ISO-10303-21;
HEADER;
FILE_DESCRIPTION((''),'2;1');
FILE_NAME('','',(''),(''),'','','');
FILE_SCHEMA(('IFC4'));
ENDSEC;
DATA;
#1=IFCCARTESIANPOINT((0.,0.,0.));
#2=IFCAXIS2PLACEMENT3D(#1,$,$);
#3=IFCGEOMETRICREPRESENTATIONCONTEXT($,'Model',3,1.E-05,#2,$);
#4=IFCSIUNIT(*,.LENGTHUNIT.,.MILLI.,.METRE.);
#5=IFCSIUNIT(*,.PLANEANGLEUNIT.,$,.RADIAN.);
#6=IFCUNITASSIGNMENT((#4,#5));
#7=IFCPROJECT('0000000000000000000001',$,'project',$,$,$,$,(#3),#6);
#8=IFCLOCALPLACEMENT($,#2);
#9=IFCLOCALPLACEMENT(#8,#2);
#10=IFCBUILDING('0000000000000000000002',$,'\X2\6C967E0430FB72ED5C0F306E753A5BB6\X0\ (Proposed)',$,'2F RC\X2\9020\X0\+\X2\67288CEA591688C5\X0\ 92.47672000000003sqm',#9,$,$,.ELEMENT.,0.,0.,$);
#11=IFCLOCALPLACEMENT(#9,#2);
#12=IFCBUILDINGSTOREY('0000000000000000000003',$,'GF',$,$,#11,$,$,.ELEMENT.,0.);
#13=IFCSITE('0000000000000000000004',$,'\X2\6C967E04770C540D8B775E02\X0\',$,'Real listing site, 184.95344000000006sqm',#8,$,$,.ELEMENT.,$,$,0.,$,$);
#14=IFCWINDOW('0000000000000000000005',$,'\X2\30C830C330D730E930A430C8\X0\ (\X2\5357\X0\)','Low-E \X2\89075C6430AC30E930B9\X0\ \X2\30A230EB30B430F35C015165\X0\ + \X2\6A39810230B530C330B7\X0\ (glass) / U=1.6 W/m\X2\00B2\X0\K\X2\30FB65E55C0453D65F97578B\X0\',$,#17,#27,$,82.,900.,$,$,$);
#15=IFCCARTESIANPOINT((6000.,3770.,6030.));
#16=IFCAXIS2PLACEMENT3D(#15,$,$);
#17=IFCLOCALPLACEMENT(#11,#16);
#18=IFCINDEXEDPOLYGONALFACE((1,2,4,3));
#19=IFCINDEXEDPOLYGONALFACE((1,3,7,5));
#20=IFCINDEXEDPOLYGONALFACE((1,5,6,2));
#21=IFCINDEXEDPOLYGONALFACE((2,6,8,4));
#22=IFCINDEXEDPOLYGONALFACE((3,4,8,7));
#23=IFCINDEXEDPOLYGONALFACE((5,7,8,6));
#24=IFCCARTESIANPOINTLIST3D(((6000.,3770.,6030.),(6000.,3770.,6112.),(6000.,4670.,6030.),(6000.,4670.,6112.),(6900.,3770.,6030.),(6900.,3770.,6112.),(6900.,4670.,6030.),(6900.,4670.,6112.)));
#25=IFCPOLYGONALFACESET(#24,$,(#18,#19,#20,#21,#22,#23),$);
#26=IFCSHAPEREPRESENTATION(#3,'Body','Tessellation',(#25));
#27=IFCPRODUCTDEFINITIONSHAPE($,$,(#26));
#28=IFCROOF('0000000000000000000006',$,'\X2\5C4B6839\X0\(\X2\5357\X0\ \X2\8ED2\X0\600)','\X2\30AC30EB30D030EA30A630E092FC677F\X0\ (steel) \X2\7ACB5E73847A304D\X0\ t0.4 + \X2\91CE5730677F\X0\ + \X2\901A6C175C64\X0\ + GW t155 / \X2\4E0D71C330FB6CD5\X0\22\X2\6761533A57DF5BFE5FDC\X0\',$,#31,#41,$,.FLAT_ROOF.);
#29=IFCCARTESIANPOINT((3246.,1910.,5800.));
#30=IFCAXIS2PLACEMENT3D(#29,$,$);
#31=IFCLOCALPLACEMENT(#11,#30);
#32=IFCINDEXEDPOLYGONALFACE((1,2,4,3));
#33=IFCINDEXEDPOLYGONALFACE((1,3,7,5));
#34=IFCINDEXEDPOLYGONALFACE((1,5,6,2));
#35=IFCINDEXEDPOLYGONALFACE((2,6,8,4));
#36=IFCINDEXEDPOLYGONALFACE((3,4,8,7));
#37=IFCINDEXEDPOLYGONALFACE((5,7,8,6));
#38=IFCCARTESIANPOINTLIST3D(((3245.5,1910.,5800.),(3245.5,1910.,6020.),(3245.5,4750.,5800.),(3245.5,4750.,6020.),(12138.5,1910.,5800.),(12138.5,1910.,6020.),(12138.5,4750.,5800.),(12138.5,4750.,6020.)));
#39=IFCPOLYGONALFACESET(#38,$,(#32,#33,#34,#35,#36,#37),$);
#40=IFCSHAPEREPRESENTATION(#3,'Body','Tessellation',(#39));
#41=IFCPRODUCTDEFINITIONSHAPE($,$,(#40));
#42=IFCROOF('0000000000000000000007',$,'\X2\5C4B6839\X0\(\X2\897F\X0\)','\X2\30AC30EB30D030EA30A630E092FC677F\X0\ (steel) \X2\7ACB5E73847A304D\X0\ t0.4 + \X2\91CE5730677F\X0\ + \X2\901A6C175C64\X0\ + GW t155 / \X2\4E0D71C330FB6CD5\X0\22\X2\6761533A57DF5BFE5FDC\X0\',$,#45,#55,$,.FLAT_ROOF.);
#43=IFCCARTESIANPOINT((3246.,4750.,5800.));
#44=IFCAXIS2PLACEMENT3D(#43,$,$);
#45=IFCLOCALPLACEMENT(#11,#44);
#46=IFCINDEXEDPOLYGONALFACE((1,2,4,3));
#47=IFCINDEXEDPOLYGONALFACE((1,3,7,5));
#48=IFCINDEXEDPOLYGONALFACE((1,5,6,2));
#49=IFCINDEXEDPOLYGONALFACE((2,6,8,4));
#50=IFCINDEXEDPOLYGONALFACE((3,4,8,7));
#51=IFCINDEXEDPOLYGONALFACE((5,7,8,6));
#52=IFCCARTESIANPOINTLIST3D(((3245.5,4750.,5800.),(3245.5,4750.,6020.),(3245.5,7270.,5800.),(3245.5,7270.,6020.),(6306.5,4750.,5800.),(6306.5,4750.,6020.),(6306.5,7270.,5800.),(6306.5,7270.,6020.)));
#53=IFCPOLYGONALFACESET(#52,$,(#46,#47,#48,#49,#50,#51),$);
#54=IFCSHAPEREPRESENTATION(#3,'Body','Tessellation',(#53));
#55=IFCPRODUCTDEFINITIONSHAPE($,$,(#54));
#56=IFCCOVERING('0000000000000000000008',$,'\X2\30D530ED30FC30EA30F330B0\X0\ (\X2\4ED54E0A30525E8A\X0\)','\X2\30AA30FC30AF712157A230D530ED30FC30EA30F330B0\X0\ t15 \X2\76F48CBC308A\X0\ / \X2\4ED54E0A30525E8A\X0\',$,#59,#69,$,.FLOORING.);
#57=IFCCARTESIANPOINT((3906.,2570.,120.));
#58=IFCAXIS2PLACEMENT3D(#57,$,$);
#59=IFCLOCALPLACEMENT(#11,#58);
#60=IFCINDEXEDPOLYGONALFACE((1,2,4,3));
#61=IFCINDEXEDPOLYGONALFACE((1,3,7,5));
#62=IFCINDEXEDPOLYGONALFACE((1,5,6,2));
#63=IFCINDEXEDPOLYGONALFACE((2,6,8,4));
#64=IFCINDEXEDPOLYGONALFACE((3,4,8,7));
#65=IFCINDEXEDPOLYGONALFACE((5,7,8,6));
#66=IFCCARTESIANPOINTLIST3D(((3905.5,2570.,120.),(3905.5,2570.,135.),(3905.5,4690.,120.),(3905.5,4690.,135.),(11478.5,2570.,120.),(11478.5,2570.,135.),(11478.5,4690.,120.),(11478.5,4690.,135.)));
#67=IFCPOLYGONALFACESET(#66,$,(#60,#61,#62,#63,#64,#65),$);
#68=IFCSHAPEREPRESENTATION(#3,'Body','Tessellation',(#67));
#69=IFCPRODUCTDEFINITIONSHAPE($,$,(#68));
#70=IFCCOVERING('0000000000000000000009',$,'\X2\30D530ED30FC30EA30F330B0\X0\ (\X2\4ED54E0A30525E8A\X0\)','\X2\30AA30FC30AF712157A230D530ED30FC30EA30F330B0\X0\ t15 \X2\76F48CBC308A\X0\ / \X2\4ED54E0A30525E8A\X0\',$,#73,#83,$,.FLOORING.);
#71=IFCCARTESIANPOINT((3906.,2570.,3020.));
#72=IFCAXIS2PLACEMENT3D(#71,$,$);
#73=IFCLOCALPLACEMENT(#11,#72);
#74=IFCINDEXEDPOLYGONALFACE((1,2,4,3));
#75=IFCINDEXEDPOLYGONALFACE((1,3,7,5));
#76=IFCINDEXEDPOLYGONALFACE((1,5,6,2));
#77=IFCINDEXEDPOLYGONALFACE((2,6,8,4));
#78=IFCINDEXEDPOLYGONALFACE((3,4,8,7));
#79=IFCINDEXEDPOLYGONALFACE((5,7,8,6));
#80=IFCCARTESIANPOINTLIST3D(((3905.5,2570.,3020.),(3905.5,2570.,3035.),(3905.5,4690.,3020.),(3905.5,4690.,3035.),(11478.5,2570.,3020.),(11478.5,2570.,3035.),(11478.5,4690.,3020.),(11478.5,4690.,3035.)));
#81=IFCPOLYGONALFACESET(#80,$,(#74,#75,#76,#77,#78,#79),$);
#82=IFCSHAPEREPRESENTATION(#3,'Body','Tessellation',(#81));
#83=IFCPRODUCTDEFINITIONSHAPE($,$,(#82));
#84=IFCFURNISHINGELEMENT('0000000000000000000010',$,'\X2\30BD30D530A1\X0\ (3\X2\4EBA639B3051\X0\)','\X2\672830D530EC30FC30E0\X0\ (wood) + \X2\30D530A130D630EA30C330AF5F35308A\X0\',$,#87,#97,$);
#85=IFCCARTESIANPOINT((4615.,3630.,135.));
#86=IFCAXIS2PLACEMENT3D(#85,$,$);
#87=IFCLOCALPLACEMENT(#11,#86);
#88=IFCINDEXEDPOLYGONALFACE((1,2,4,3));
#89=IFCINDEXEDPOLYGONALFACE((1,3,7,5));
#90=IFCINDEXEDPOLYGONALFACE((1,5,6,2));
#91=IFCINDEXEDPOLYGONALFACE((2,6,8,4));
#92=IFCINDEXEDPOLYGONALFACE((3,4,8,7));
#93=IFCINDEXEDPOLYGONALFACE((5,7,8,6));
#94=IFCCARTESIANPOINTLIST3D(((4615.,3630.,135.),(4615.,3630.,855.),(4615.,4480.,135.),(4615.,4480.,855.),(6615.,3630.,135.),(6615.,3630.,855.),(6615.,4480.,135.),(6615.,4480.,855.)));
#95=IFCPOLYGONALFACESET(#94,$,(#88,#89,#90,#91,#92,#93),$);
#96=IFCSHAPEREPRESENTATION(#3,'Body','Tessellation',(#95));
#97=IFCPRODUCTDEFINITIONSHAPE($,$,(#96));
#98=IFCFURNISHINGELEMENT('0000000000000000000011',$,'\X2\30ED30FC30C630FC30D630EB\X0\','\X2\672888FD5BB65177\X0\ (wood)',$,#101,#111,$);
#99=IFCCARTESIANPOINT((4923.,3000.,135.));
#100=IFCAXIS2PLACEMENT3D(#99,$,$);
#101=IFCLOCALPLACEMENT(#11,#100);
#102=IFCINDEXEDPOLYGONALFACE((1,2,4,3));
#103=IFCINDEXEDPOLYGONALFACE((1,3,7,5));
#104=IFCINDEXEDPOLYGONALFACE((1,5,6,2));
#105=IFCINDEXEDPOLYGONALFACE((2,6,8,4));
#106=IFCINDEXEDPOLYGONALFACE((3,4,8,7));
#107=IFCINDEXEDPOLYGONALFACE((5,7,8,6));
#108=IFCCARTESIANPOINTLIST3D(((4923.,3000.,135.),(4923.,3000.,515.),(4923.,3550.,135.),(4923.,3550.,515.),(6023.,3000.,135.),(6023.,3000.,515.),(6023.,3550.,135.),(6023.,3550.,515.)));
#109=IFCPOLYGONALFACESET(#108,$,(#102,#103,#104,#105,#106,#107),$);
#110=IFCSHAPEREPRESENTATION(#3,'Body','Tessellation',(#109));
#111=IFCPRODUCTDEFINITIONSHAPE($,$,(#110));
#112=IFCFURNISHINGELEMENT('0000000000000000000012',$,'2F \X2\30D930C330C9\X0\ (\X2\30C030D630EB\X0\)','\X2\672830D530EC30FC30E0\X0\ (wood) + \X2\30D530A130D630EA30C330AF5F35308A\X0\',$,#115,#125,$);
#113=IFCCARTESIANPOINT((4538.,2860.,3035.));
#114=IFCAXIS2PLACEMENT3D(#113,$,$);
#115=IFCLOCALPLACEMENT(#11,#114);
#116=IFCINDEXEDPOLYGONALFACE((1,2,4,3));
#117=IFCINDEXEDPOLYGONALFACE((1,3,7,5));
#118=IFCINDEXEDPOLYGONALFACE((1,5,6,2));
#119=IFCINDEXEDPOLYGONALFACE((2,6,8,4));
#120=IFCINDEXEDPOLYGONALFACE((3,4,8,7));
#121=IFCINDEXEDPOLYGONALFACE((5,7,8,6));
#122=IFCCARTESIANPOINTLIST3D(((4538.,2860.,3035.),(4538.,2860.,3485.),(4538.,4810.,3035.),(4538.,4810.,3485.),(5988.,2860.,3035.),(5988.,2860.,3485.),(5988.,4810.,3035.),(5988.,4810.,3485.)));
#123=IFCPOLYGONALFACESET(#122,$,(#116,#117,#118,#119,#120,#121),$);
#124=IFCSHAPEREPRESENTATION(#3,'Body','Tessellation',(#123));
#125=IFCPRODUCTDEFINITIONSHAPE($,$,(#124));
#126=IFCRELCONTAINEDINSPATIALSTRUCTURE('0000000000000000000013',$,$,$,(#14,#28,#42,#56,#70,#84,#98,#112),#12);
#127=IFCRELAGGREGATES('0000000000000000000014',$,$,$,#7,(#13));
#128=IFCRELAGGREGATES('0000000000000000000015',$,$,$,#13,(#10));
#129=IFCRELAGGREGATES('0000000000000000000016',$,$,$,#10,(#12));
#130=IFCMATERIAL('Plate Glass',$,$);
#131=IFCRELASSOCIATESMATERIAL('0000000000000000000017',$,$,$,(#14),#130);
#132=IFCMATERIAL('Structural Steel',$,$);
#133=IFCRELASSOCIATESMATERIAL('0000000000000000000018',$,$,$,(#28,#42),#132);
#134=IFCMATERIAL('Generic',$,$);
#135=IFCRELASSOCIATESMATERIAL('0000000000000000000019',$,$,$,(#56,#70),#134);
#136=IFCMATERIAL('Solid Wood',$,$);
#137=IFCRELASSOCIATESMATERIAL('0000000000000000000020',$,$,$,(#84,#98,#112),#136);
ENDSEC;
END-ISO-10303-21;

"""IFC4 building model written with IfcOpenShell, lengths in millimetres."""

from ifc_helpers import new_model, si_unit, frame, frame_2d, origin, place, context, project, spatial, rectangle, extrude, material, element, save


model = new_model("IFC4")

# Units and contexts
model_context = context("Model", 3, precision=1e-05, world=origin())
ifc_project = project(units=[si_unit("LENGTHUNIT", "METRE", prefix="MILLI"), si_unit("PLANEANGLEUNIT", "RADIAN")], contexts=[model_context])

# Site, building, storey
site_placement = place(None, origin())
site = spatial("IfcSite", under=ifc_project, at=site_placement, Name="沖縄県名護市", ObjectType="Real listing site, 184.95344000000006sqm", CompositionType="ELEMENT", RefElevation=0.0)
building_placement = place(site_placement, origin())
building = spatial("IfcBuilding", under=site, at=building_placement, Name="沖縄・狭小の町家 (Proposed)", ObjectType="2F RC造+木質外装 92.47672000000003sqm", CompositionType="ELEMENT", ElevationOfRefHeight=0.0, ElevationOfTerrain=0.0)
storey_placement = place(building_placement, origin())
storey = spatial("IfcBuildingStorey", under=building, at=storey_placement, Name="GF", CompositionType="ELEMENT", Elevation=0.0)

# Shared definitions
ifc_material_1 = material(Name="Solid Wood")

# Shared definitions
ifc_material_2 = material(Name="Plate Glass")

# Window
window_1_placement = place(storey_placement, frame((6000.0, 3770.0, 6030.0)))
element("IfcWindow", 1, at=window_1_placement, inside=storey, material=ifc_material_2, Name="トップライト (南)", Description="Low-E 複層ガラス アルゴン封入 + 樹脂サッシ (glass) / U=1.6 W/m²K・日射取得型", OverallHeight=82.0, OverallWidth=900.0, context=model_context, shape_type="SweptSolid", body=[
    extrude(rectangle(XDim=900.0, YDim=900.0, at=frame_2d((450.0, 450.0))), frame((6000.0, 3770.0, 6030.0)), (0.0, 0.0, 1.0), 82.0),
])

# Roofs
ifc_material_3 = material(Name="Structural Steel")
roof_1_placement = place(storey_placement, frame((3246.0, 1910.0, 5800.0)))
element("IfcRoof", 2, at=roof_1_placement, inside=storey, material=ifc_material_3, Name="屋根(南 軒600)", Description="ガルバリウム鋼板 (steel) 立平葺き t0.4 + 野地板 + 通気層 + GW t155 / 不燃・法22条区域対応", PredefinedType="FLAT_ROOF", context=model_context, shape_type="SweptSolid", body=[
    extrude(rectangle(XDim=8893.0, YDim=2840.0, at=frame_2d((4446.0, 1420.0))), frame((3246.0, 1910.0, 5800.0)), (0.0, 0.0, 1.0), 220.0),
])
roof_2_placement = place(storey_placement, frame((3246.0, 4750.0, 5800.0)))
element("IfcRoof", 3, at=roof_2_placement, inside=storey, material=ifc_material_3, Name="屋根(西)", Description="ガルバリウム鋼板 (steel) 立平葺き t0.4 + 野地板 + 通気層 + GW t155 / 不燃・法22条区域対応", PredefinedType="FLAT_ROOF", context=model_context, shape_type="SweptSolid", body=[
    extrude(rectangle(XDim=3061.0, YDim=2520.0, at=frame_2d((1530.0, 1260.0))), frame((3246.0, 4750.0, 5800.0)), (0.0, 0.0, 1.0), 220.0),
])

# Coverings
ifc_material_4 = material(Name="Generic")
covering_1_placement = place(storey_placement, frame((3906.0, 2570.0, 120.0)))
element("IfcCovering", 4, at=covering_1_placement, inside=storey, material=ifc_material_4, Name="フローリング (仕上げ床)", Description="オーク無垢フローリング t15 直貼り / 仕上げ床", PredefinedType="FLOORING", context=model_context, shape_type="SweptSolid", body=[
    extrude(rectangle(XDim=7573.0, YDim=2120.0, at=frame_2d((3786.0, 1060.0))), frame((3906.0, 2570.0, 120.0)), (0.0, 0.0, 1.0), 15.0),
])
covering_2_placement = place(storey_placement, frame((3906.0, 2570.0, 3020.0)))
element("IfcCovering", 5, at=covering_2_placement, inside=storey, material=ifc_material_4, Name="フローリング (仕上げ床)", Description="オーク無垢フローリング t15 直貼り / 仕上げ床", PredefinedType="FLOORING", context=model_context, shape_type="SweptSolid", body=[
    extrude(rectangle(XDim=7573.0, YDim=2120.0, at=frame_2d((3786.0, 1060.0))), frame((3906.0, 2570.0, 3020.0)), (0.0, 0.0, 1.0), 15.0),
])

# Furnishing elements
furnishing_1_placement = place(storey_placement, frame((4615.0, 3630.0, 135.0)))
element("IfcFurnishingElement", 6, at=furnishing_1_placement, inside=storey, material=ifc_material_1, Name="ソファ (3人掛け)", Description="木フレーム (wood) + ファブリック張り", context=model_context, shape_type="SweptSolid", body=[
    extrude(rectangle(XDim=2000.0, YDim=850.0, at=frame_2d((1000.0, 425.0))), frame((4615.0, 3630.0, 135.0)), (0.0, 0.0, 1.0), 720.0),
])
furnishing_2_placement = place(storey_placement, frame((4923.0, 3000.0, 135.0)))
element("IfcFurnishingElement", 7, at=furnishing_2_placement, inside=storey, material=ifc_material_1, Name="ローテーブル", Description="木製家具 (wood)", context=model_context, shape_type="SweptSolid", body=[
    extrude(rectangle(XDim=1100.0, YDim=550.0, at=frame_2d((550.0, 275.0))), frame((4923.0, 3000.0, 135.0)), (0.0, 0.0, 1.0), 380.0),
])
furnishing_3_placement = place(storey_placement, frame((4538.0, 2860.0, 3035.0)))
element("IfcFurnishingElement", 8, at=furnishing_3_placement, inside=storey, material=ifc_material_1, Name="2F ベッド (ダブル)", Description="木フレーム (wood) + ファブリック張り", context=model_context, shape_type="SweptSolid", body=[
    extrude(rectangle(XDim=1450.0, YDim=1950.0, at=frame_2d((725.0, 975.0))), frame((4538.0, 2860.0, 3035.0)), (0.0, 0.0, 1.0), 450.0),
])

save(model, "model.ifc")
